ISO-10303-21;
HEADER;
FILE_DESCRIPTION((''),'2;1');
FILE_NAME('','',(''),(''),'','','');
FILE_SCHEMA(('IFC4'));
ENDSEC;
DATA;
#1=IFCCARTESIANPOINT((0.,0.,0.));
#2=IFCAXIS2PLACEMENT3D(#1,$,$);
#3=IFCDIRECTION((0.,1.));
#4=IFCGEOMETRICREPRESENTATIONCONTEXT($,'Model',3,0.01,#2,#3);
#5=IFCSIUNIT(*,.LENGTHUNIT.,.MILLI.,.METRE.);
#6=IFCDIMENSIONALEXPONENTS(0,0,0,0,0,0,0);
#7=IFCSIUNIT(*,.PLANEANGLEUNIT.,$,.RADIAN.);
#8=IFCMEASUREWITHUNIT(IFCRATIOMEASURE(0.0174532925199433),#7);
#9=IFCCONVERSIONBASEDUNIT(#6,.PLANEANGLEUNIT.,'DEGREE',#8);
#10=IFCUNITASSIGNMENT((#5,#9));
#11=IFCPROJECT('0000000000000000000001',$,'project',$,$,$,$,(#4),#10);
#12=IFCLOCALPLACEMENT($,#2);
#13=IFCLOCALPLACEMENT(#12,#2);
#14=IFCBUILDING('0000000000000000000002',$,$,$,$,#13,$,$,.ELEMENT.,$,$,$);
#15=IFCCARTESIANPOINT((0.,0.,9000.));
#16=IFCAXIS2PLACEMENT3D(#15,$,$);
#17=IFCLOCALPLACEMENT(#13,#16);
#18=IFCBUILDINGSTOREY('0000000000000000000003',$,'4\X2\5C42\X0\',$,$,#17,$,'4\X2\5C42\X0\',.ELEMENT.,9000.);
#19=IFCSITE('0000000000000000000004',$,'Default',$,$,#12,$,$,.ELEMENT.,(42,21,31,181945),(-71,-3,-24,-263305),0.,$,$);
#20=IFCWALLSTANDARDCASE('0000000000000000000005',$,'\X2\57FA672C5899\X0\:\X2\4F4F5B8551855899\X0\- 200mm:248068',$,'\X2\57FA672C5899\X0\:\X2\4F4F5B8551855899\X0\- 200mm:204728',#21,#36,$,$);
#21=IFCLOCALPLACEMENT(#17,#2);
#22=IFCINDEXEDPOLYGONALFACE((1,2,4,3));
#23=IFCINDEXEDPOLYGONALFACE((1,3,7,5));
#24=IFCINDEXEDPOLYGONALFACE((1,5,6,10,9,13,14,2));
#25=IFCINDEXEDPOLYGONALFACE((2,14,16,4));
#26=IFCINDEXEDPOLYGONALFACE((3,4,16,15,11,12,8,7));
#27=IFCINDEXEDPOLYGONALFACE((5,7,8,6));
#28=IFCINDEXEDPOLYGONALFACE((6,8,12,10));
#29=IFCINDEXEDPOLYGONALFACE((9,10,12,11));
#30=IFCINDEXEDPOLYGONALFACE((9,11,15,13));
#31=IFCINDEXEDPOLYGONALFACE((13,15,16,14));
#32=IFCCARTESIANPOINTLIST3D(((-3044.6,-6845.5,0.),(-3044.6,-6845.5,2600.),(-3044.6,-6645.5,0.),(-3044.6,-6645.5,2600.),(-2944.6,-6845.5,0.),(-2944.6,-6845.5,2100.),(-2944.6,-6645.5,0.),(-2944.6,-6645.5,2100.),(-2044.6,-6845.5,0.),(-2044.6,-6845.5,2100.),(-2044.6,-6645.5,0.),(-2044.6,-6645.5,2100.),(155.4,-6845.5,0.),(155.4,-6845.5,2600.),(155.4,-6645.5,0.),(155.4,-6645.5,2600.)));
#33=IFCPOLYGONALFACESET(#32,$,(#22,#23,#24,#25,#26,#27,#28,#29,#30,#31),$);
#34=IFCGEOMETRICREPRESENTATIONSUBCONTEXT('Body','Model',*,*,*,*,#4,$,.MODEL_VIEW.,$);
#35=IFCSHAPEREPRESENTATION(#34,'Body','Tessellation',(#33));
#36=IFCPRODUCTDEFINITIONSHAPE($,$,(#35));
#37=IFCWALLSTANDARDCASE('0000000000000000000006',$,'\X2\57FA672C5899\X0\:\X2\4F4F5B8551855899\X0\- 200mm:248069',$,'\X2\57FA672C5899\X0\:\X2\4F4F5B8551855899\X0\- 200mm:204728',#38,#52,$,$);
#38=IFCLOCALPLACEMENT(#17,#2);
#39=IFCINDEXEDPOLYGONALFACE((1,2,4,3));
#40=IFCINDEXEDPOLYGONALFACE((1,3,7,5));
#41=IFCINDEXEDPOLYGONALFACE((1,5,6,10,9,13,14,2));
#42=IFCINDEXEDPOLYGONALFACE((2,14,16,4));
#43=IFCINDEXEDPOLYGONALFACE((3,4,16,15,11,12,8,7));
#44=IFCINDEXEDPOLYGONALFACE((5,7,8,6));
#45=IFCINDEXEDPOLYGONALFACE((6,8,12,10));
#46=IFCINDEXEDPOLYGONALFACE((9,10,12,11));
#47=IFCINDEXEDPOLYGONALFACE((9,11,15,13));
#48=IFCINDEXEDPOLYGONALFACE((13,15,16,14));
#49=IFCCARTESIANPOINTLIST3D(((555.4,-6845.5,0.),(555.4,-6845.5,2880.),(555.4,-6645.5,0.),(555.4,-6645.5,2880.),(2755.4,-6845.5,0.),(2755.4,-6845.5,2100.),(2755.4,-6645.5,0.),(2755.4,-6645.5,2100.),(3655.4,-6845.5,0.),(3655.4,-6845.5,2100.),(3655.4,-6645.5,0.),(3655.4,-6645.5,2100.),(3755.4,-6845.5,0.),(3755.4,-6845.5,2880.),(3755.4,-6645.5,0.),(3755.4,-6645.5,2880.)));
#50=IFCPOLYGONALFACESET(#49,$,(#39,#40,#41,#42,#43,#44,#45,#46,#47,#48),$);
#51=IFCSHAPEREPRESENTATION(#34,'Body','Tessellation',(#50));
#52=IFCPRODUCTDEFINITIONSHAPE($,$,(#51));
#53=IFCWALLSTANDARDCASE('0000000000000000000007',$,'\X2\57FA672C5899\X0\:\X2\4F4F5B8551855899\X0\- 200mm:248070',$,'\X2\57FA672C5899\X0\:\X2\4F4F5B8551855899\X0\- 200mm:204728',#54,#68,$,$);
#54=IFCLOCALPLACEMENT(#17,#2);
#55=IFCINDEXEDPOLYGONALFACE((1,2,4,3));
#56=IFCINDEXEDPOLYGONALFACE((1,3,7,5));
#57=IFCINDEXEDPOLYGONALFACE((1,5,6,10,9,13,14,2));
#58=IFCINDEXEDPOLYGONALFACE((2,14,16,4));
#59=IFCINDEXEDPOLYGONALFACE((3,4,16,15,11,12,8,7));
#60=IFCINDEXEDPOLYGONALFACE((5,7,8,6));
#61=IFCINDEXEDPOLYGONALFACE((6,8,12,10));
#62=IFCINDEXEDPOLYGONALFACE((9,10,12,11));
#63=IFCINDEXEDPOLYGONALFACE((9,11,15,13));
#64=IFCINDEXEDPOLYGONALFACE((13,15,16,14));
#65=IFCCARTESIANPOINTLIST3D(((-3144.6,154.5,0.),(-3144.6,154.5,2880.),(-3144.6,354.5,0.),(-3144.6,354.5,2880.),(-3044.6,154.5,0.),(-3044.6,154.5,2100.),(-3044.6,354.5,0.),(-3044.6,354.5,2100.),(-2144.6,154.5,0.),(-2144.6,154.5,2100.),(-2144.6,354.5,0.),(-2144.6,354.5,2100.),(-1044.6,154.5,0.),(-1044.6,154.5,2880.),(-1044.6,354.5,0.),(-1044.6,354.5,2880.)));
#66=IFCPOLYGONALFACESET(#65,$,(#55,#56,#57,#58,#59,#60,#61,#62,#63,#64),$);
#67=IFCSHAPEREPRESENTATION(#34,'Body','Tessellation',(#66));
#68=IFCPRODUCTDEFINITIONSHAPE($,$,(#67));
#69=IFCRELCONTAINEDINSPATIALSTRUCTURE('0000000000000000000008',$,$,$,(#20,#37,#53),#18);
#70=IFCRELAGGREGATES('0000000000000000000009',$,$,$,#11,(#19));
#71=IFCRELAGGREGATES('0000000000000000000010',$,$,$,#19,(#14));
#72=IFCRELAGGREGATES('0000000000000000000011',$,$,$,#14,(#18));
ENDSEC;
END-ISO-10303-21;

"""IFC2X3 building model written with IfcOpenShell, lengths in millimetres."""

from ifc_helpers import new_model, entity, si_unit, converted_unit, direction, frame, frame_2d, origin, place, context, subcontext, project, spatial, polyline, rectangle, extrude, clip, bounded_halfspace, element, save


model = new_model("IFC2X3")

# Units and contexts
model_context = context("Model", 3, precision=0.01, world=origin(), true_north=direction((0.0, 1.0)))
body_context = subcontext(model_context, "Body", "Model", "MODEL_VIEW")
ifc_project = project(units=[si_unit("LENGTHUNIT", "METRE", prefix="MILLI"), converted_unit("PLANEANGLEUNIT", "DEGREE", entity("IfcRatioMeasure", 0.0174532925199433), si_unit("PLANEANGLEUNIT", "RADIAN"), dimensions=[0, 0, 0, 0, 0, 0, 0])], contexts=[model_context])

# Site, building, storey
site_placement = place(None, origin())
site = spatial("IfcSite", under=ifc_project, at=site_placement, Name="Default", CompositionType="ELEMENT", RefLatitude=(42, 21, 31, 181945), RefLongitude=(-71, -3, -24, -263305), RefElevation=0.0)
building_placement = place(site_placement, origin())
building = spatial("IfcBuilding", under=site, at=building_placement, CompositionType="ELEMENT")
storey_placement = place(building_placement, frame((0.0, 0.0, 9000.0)))
storey = spatial("IfcBuildingStorey", under=building, at=storey_placement, Name="4层", LongName="4层", CompositionType="ELEMENT", Elevation=9000.0)

# Walls, openings
wall_1_placement = place(storey_placement, frame((-3044.6, -6745.5, 0.0)))
wall_1 = element("IfcWallStandardCase", 1, at=wall_1_placement, inside=storey, Name="基本墙:住宅内墙- 200mm:248068", ObjectType="基本墙:住宅内墙- 200mm:204728", context=body_context, shape_type="Clipping", body=[
    clip(clip(clip(extrude(rectangle(XDim=3200.0, YDim=200.0, at=frame_2d((1600.0, 0.0), x_axis=(-1.0, 0.0))), origin(), (0.0, 0.0, 1.0), 2600.0), bounded_halfspace(frame((0.0, 100.0, 0.0), z_axis=(1.0, 0.0, 0.0), x_axis=(0.0, 0.0, -1.0)), True, frame((0.0, 100.0, 0.0), z_axis=(1.0, 0.0, 0.0), x_axis=(0.0, 0.0, -1.0)), polyline([(0.0, 0.0), (-2600.0, 0.0), (-2600.0, -200.0), (0.0, -200.0), (0.0, 0.0)]))), bounded_halfspace(frame((3200.0, -100.0, 0.0), z_axis=(-1.0, 0.0, 0.0), x_axis=(0.0, 0.0, -1.0)), True, frame((3200.0, -100.0, 0.0), z_axis=(-1.0, 0.0, 0.0), x_axis=(0.0, 0.0, -1.0)), polyline([(0.0, 0.0), (-2600.0, 0.0), (-2600.0, -200.0), (0.0, -200.0), (0.0, 0.0)]))), bounded_halfspace(frame((0.0, -100.0, 2600.0), z_axis=(0.0, 0.0, 1.0), x_axis=(0.0, 1.0, 0.0)), False, frame((0.0, -100.0, 2600.0), z_axis=(0.0, 0.0, 1.0), x_axis=(0.0, 1.0, 0.0)), polyline([(0.0, 0.0), (0.0, -3200.0), (200.0, -3200.0), (200.0, 0.0), (0.0, 0.0)]))),
])
opening_1_placement = place(wall_1_placement, frame((1000.0, 100.0, 0.0)))
element("IfcOpeningElement", 2, at=opening_1_placement, cuts=wall_1, ObjectType="Opening", context=body_context, shape_type="SweptSolid", body=[
    extrude(rectangle(XDim=2100.0, YDim=900.0, at=frame_2d((1050.0, 450.0), x_axis=(1.0, 0.0))), frame((0.0, 0.0, 0.0), z_axis=(0.0, -1.0, 0.0), x_axis=(0.0, 0.0, 1.0)), (0.0, 0.0, 1.0), 200.0),
])
wall_2_placement = place(storey_placement, frame((3755.4, -6745.5, 0.0), z_axis=(0.0, 0.0, 1.0), x_axis=(-1.0, 0.0, 0.0)))
wall_2 = element("IfcWallStandardCase", 3, at=wall_2_placement, inside=storey, Name="基本墙:住宅内墙- 200mm:248069", ObjectType="基本墙:住宅内墙- 200mm:204728", context=body_context, shape_type="Clipping", body=[
    clip(clip(clip(extrude(rectangle(XDim=3200.0, YDim=200.0, at=frame_2d((1600.0, 0.0), x_axis=(-1.0, 0.0))), origin(), (0.0, 0.0, 1.0), 2880.0), bounded_halfspace(frame((0.0, 100.0, 2880.0), z_axis=(0.0, 0.0, -1.0), x_axis=(0.0, 1.0, 0.0)), True, frame((0.0, 100.0, 2880.0)), polyline([(0.0, 0.0), (0.0, -200.0), (3200.0, -200.0), (3200.0, 0.0), (0.0, 0.0)]))), bounded_halfspace(frame((0.0, -100.0, 0.0), z_axis=(-1.0, 0.0, 0.0), x_axis=(0.0, 0.0, -1.0)), False, frame((0.0, -100.0, 0.0), z_axis=(-1.0, 0.0, 0.0), x_axis=(0.0, 0.0, -1.0)), polyline([(0.0, 0.0), (-2880.0, 0.0), (-2880.0, -200.0), (0.0, -200.0), (0.0, 0.0)]))), bounded_halfspace(frame((3200.0, -100.0, 2880.0), z_axis=(-1.0, 0.0, 0.0), x_axis=(0.0, 0.0, -1.0)), True, frame((3200.0, -100.0, 2880.0), z_axis=(-1.0, 0.0, 0.0), x_axis=(0.0, 0.0, -1.0)), polyline([(0.0, 0.0), (0.0, -200.0), (2880.0, -200.0), (2880.0, 0.0), (0.0, 0.0)]))),
])
opening_2_placement = place(wall_2_placement, frame((100.0, -100.0, 0.0)))
element("IfcOpeningElement", 4, at=opening_2_placement, cuts=wall_2, ObjectType="Opening", context=body_context, shape_type="SweptSolid", body=[
    extrude(rectangle(XDim=2100.0, YDim=900.0, at=frame_2d((1050.0, 450.0), x_axis=(1.0, 0.0))), frame((0.0, 0.0, 0.0), z_axis=(0.0, 1.0, 0.0), x_axis=(0.0, 0.0, 1.0)), (0.0, 0.0, 1.0), 200.0),
])
wall_3_placement = place(storey_placement, frame((-3144.6, 254.5, 0.0)))
wall_3 = element("IfcWallStandardCase", 5, at=wall_3_placement, inside=storey, Name="基本墙:住宅内墙- 200mm:248070", ObjectType="基本墙:住宅内墙- 200mm:204728", context=body_context, shape_type="Clipping", body=[
    clip(extrude(rectangle(XDim=2100.0, YDim=200.0, at=frame_2d((1050.0, 0.0), x_axis=(-1.0, 0.0))), origin(), (0.0, 0.0, 1.0), 2880.0), bounded_halfspace(frame((0.0, -100.0, 2880.0), z_axis=(0.0, 0.0, -1.0), x_axis=(0.0, -1.0, 0.0)), True, frame((0.0, -100.0, 2880.0)), polyline([(0.0, 0.0), (2100.0, 0.0), (2100.0, 200.0), (0.0, 200.0), (0.0, 0.0)]))),
])
opening_3_placement = place(wall_3_placement, frame((100.0, -100.0, 0.0)))
element("IfcOpeningElement", 6, at=opening_3_placement, cuts=wall_3, ObjectType="Opening", context=body_context, shape_type="SweptSolid", body=[
    extrude(rectangle(XDim=2100.0, YDim=900.0, at=frame_2d((1050.0, 450.0), x_axis=(1.0, 0.0))), frame((0.0, 0.0, 0.0), z_axis=(0.0, 1.0, 0.0), x_axis=(0.0, 0.0, 1.0)), (0.0, 0.0, 1.0), 200.0),
])

save(model, "model.ifc")
